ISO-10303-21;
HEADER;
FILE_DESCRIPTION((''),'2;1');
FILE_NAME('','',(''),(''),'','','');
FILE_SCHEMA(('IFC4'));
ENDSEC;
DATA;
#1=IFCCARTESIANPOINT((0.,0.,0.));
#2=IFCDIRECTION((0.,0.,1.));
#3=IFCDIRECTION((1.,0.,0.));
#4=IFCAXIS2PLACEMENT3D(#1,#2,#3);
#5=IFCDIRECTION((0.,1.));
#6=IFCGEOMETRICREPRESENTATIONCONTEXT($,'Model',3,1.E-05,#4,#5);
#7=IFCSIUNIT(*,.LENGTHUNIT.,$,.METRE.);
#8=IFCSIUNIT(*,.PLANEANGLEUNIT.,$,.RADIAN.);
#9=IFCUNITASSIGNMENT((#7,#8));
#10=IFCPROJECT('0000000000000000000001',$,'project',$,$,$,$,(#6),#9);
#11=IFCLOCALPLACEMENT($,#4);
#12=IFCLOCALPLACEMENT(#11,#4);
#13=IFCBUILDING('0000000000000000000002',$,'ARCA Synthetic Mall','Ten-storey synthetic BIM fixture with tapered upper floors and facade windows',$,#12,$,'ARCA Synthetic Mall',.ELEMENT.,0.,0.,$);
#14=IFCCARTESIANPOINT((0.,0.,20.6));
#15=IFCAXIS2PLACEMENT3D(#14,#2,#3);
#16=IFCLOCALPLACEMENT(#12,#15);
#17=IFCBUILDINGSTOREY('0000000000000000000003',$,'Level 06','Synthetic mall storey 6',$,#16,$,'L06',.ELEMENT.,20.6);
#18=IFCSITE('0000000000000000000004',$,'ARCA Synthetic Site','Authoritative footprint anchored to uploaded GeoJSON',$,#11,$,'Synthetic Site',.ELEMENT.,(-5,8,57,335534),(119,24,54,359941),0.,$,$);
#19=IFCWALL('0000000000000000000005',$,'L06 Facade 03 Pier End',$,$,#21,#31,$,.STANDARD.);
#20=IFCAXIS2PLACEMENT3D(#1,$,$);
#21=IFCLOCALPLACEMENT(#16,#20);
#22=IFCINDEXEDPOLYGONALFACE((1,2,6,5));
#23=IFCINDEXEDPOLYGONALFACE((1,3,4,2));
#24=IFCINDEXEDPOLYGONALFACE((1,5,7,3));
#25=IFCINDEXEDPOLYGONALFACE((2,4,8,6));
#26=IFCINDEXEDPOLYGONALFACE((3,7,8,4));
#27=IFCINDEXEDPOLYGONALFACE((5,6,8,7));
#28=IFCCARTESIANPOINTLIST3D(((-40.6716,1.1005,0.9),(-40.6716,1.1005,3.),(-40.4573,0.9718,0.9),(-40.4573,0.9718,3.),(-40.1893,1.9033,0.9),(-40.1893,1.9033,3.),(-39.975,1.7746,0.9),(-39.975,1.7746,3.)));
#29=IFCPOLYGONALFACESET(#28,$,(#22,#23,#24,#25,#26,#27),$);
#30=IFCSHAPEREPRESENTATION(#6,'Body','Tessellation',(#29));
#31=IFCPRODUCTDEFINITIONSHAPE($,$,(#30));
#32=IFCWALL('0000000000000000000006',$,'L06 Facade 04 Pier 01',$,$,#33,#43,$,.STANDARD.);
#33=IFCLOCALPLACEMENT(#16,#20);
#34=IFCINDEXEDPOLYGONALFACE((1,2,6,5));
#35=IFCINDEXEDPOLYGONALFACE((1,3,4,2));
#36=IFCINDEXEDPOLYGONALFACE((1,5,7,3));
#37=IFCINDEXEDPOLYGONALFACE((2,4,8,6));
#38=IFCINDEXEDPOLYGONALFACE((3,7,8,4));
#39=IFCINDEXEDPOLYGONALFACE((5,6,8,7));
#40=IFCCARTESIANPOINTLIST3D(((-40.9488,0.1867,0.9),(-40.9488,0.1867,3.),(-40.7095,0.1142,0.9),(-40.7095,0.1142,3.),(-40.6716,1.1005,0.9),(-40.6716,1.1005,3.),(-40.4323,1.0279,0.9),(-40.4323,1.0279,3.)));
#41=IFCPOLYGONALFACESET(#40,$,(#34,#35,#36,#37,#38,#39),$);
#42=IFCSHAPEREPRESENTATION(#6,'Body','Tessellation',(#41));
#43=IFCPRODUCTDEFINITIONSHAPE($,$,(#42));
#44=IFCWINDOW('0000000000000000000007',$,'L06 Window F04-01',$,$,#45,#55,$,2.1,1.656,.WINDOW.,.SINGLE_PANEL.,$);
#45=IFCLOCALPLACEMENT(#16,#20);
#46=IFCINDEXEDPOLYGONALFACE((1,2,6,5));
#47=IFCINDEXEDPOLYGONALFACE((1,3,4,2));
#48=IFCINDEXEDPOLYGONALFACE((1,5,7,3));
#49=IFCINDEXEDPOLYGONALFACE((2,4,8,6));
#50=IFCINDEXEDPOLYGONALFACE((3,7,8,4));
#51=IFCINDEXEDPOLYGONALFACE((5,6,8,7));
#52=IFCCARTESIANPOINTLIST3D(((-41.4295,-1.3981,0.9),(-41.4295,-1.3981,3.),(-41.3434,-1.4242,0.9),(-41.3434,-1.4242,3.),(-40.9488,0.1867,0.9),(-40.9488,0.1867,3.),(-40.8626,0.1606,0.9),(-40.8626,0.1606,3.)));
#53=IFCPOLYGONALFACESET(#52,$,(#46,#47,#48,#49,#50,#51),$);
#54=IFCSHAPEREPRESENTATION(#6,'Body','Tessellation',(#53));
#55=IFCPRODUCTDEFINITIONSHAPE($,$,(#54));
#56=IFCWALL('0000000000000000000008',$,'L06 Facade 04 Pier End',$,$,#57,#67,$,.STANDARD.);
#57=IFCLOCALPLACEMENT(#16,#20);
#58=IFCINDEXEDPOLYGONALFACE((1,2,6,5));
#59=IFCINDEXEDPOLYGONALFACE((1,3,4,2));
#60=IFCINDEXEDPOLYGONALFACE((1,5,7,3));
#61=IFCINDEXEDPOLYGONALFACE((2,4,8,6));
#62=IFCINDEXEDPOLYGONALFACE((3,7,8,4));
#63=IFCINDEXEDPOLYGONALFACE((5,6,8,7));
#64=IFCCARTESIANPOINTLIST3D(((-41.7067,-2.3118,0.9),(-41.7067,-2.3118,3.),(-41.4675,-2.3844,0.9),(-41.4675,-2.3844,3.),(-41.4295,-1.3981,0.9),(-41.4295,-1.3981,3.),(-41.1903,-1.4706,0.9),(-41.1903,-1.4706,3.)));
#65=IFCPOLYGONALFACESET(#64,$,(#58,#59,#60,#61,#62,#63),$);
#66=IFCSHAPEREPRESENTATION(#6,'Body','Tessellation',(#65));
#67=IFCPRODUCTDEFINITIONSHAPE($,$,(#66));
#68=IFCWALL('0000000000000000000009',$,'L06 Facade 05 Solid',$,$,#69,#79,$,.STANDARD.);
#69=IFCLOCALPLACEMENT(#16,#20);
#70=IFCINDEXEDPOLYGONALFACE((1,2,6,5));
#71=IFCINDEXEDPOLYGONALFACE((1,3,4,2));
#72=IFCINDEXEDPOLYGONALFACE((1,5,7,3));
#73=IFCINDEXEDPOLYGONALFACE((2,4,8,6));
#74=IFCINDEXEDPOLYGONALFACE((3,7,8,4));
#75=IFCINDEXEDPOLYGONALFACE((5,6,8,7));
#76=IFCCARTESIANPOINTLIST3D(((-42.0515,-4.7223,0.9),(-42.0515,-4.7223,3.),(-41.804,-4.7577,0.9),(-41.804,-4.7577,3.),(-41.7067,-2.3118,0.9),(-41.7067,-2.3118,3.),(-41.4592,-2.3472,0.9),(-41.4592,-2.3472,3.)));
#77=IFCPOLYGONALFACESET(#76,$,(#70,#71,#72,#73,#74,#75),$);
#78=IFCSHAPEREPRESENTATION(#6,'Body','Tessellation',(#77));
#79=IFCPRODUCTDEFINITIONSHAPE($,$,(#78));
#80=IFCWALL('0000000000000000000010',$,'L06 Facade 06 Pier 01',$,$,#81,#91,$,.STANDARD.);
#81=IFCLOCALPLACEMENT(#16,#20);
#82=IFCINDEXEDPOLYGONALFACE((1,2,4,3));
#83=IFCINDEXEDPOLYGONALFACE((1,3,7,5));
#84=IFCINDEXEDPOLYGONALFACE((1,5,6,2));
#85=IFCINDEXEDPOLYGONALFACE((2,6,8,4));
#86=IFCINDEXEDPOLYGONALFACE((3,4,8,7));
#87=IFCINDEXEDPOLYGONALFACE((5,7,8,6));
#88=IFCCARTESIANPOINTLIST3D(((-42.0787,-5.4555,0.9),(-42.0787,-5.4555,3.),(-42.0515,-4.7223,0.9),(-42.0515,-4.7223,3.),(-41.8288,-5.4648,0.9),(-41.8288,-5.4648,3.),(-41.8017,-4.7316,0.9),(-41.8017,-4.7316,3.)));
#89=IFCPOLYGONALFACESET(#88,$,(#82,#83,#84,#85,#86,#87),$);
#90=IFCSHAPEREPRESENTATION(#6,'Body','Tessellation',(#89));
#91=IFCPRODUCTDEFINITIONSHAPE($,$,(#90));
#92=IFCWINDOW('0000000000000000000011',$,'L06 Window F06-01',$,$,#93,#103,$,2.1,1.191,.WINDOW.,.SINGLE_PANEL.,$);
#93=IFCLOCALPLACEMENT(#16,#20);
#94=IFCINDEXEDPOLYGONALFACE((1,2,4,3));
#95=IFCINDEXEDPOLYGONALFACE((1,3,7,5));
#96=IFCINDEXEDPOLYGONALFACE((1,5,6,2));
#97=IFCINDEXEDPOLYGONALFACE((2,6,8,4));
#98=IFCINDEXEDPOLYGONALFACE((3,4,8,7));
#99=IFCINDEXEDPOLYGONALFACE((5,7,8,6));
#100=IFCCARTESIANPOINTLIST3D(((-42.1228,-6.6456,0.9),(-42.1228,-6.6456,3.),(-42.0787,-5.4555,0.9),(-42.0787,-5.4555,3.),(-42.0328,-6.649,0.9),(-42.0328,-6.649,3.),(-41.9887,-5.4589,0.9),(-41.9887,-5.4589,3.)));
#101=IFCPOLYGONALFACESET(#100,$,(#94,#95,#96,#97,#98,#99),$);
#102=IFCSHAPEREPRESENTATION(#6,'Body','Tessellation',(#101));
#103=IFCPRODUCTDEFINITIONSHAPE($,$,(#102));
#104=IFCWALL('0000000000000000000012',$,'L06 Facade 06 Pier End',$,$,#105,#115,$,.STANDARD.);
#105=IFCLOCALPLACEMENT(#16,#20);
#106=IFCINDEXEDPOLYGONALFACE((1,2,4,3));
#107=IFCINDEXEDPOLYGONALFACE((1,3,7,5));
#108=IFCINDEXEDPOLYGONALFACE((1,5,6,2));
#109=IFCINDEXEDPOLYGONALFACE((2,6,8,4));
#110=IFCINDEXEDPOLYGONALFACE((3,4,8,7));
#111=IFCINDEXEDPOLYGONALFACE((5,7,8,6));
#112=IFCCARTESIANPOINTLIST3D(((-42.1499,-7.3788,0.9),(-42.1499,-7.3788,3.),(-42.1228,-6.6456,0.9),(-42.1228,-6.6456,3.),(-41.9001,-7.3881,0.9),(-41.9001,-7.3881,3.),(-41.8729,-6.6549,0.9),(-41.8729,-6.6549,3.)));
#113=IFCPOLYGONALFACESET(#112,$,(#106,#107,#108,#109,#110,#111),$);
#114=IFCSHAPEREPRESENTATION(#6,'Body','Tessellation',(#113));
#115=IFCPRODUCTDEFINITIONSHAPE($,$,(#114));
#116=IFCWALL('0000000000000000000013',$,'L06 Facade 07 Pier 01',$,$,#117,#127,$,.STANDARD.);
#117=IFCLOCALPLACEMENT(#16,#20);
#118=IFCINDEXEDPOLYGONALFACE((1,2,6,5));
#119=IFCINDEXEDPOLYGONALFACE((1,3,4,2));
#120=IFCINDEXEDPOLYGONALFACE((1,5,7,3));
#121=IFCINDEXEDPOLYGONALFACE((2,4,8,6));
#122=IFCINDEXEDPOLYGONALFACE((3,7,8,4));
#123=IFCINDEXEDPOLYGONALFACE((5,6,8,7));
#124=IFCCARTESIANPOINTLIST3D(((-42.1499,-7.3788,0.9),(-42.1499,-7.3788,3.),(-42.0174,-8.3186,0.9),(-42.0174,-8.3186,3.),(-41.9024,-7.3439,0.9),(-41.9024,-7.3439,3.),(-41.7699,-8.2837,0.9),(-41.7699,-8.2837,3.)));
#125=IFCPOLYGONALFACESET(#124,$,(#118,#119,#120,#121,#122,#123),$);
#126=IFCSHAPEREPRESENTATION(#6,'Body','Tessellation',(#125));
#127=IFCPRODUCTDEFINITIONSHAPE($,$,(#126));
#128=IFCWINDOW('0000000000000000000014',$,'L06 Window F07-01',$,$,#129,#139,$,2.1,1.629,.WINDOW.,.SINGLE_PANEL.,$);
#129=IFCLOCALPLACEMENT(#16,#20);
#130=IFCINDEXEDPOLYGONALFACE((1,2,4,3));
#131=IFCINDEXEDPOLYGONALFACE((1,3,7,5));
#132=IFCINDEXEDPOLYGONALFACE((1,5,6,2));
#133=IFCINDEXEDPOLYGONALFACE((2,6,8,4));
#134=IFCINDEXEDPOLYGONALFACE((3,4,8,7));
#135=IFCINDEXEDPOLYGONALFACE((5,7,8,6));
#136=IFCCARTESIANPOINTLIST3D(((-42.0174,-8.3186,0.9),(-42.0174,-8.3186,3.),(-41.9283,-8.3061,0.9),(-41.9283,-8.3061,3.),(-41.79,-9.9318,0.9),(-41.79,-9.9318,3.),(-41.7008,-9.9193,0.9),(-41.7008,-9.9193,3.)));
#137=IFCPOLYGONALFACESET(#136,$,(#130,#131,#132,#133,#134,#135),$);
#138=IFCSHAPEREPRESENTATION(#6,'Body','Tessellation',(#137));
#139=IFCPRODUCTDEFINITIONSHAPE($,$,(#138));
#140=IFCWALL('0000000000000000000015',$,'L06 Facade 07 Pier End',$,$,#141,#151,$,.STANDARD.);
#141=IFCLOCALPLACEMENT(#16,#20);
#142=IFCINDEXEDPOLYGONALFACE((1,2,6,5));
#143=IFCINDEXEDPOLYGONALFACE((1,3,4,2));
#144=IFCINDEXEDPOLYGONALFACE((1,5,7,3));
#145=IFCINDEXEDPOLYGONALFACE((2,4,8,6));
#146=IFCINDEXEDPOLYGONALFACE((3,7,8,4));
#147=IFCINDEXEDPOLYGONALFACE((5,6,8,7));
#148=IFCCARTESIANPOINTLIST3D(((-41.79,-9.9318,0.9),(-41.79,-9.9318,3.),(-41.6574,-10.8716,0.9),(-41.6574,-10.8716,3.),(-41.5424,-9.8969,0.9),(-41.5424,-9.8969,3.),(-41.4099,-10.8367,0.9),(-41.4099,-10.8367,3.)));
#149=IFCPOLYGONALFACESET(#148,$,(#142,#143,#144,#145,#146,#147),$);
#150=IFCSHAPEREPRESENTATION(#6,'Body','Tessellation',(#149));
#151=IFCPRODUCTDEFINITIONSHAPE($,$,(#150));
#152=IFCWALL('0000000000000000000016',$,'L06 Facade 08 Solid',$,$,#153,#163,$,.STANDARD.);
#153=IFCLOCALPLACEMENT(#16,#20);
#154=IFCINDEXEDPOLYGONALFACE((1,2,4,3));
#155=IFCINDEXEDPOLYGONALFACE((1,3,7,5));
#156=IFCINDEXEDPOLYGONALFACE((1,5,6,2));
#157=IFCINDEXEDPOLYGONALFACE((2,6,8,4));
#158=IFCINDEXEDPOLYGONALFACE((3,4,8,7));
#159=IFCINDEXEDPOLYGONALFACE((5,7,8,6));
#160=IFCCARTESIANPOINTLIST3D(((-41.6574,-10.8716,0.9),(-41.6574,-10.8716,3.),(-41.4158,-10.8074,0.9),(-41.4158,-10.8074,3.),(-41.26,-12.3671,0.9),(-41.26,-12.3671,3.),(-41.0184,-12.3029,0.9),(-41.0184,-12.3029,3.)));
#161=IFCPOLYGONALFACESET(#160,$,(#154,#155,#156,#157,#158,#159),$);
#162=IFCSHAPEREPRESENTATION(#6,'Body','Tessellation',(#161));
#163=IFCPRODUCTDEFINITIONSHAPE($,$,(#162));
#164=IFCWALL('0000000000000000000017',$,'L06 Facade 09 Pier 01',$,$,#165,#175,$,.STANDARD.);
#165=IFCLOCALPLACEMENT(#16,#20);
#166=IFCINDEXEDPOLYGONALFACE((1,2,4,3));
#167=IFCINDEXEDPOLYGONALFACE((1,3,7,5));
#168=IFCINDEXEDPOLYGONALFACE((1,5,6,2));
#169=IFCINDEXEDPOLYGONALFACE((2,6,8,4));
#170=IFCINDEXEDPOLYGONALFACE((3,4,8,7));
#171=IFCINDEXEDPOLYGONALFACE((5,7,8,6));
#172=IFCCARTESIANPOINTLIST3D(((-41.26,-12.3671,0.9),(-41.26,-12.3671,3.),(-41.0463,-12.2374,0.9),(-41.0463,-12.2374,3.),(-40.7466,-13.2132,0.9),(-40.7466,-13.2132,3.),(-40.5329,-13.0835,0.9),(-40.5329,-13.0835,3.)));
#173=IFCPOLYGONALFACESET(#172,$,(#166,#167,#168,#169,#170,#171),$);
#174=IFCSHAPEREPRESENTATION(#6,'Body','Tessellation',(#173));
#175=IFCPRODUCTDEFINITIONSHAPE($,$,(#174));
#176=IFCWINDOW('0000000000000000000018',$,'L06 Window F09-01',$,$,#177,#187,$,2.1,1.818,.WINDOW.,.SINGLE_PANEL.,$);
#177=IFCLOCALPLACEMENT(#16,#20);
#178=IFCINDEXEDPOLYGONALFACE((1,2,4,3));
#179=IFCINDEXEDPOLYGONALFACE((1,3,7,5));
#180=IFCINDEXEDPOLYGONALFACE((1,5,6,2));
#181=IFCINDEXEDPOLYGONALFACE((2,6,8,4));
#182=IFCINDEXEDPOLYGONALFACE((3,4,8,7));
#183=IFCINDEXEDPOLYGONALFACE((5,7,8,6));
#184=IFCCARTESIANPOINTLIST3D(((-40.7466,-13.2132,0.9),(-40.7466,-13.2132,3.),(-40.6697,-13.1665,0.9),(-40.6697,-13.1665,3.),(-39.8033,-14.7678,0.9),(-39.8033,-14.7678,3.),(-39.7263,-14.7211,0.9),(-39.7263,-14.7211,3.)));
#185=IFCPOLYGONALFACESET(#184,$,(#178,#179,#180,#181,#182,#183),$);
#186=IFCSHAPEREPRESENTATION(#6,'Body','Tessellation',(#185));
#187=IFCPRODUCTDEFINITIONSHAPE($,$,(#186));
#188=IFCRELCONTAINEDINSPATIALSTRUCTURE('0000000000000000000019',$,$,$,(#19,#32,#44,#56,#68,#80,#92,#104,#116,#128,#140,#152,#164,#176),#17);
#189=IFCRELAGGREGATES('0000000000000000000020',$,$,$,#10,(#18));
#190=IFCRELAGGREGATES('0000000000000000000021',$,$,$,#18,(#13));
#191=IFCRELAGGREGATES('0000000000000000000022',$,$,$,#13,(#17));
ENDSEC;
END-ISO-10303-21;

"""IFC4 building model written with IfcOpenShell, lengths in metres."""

from ifc_helpers import new_model, si_unit, direction, frame, origin_with_axes, place, context, project, spatial, polyline, outline, extrude, element, save


model = new_model("IFC4")

# Units and contexts
model_context = context("Model", 3, precision=1e-05, world=origin_with_axes(), true_north=direction((0.0, 1.0)))
ifc_project = project(units=[si_unit("LENGTHUNIT", "METRE"), si_unit("PLANEANGLEUNIT", "RADIAN")], contexts=[model_context])

# Site, building, storey
site_placement = place(None, origin_with_axes())
site = spatial("IfcSite", under=ifc_project, at=site_placement, Name="ARCA Synthetic Site", Description="Authoritative footprint anchored to uploaded GeoJSON", LongName="Synthetic Site", CompositionType="ELEMENT", RefLatitude=(-5, 8, 57, 335534), RefLongitude=(119, 24, 54, 359941), RefElevation=0.0)
building_placement = place(site_placement, origin_with_axes())
building = spatial("IfcBuilding", under=site, at=building_placement, Name="ARCA Synthetic Mall", Description="Ten-storey synthetic BIM fixture with tapered upper floors and facade windows", LongName="ARCA Synthetic Mall", CompositionType="ELEMENT", ElevationOfRefHeight=0.0, ElevationOfTerrain=0.0)
storey_placement = place(building_placement, frame((0.0, 0.0, 20.6), z_axis=(0.0, 0.0, 1.0), x_axis=(1.0, 0.0, 0.0)))
storey = spatial("IfcBuildingStorey", under=building, at=storey_placement, Name="Level 06", Description="Synthetic mall storey 6", LongName="L06", CompositionType="ELEMENT", Elevation=20.6)

# Walls
wall_1_placement = place(storey_placement, frame((0.0, 0.0, 0.9), z_axis=(0.0, 0.0, 1.0), x_axis=(1.0, 0.0, 0.0)))
element("IfcWall", 1, at=wall_1_placement, inside=storey, Name="L06 Facade 03 Pier End", PredefinedType="STANDARD", context=model_context, shape_type="SweptSolid", body=[
    extrude(outline(polyline([(-40.1893, 1.9033), (-40.6716, 1.1005), (-40.4573, 0.9718), (-39.975, 1.7746), (-40.1893, 1.9033)])), origin_with_axes(), (0.0, 0.0, 1.0), 2.1),
])
wall_2_placement = place(storey_placement, frame((0.0, 0.0, 0.9), z_axis=(0.0, 0.0, 1.0), x_axis=(1.0, 0.0, 0.0)))
element("IfcWall", 2, at=wall_2_placement, inside=storey, Name="L06 Facade 04 Pier 01", PredefinedType="STANDARD", context=model_context, shape_type="SweptSolid", body=[
    extrude(outline(polyline([(-40.6716, 1.1005), (-40.9488, 0.1867), (-40.7095, 0.1142), (-40.4323, 1.0279), (-40.6716, 1.1005)])), origin_with_axes(), (0.0, 0.0, 1.0), 2.1),
])

# Window
window_1_placement = place(storey_placement, frame((0.0, 0.0, 0.9), z_axis=(0.0, 0.0, 1.0), x_axis=(1.0, 0.0, 0.0)))
element("IfcWindow", 3, at=window_1_placement, inside=storey, Name="L06 Window F04-01", OverallHeight=2.1, OverallWidth=1.656, PartitioningType="SINGLE_PANEL", PredefinedType="WINDOW", context=model_context, shape_type="SweptSolid", body=[
    extrude(outline(polyline([(-40.9488, 0.1867), (-41.4295, -1.3981), (-41.3434, -1.4242), (-40.8626, 0.1606), (-40.9488, 0.1867)])), origin_with_axes(), (0.0, 0.0, 1.0), 2.1),
])

# Walls
wall_3_placement = place(storey_placement, frame((0.0, 0.0, 0.9), z_axis=(0.0, 0.0, 1.0), x_axis=(1.0, 0.0, 0.0)))
element("IfcWall", 4, at=wall_3_placement, inside=storey, Name="L06 Facade 04 Pier End", PredefinedType="STANDARD", context=model_context, shape_type="SweptSolid", body=[
    extrude(outline(polyline([(-41.4295, -1.3981), (-41.7067, -2.3118), (-41.4675, -2.3844), (-41.1903, -1.4706), (-41.4295, -1.3981)])), origin_with_axes(), (0.0, 0.0, 1.0), 2.1),
])
wall_4_placement = place(storey_placement, frame((0.0, 0.0, 0.9), z_axis=(0.0, 0.0, 1.0), x_axis=(1.0, 0.0, 0.0)))
element("IfcWall", 5, at=wall_4_placement, inside=storey, Name="L06 Facade 05 Solid", PredefinedType="STANDARD", context=model_context, shape_type="SweptSolid", body=[
    extrude(outline(polyline([(-41.7067, -2.3118), (-42.0515, -4.7223), (-41.804, -4.7577), (-41.4592, -2.3472), (-41.7067, -2.3118)])), origin_with_axes(), (0.0, 0.0, 1.0), 2.1),
])
wall_5_placement = place(storey_placement, frame((0.0, 0.0, 0.9), z_axis=(0.0, 0.0, 1.0), x_axis=(1.0, 0.0, 0.0)))
element("IfcWall", 6, at=wall_5_placement, inside=storey, Name="L06 Facade 06 Pier 01", PredefinedType="STANDARD", context=model_context, shape_type="SweptSolid", body=[
    extrude(outline(polyline([(-42.0515, -4.7223), (-42.0787, -5.4555), (-41.8288, -5.4648), (-41.8017, -4.7316), (-42.0515, -4.7223)])), origin_with_axes(), (0.0, 0.0, 1.0), 2.1),
])

# Window
window_2_placement = place(storey_placement, frame((0.0, 0.0, 0.9), z_axis=(0.0, 0.0, 1.0), x_axis=(1.0, 0.0, 0.0)))
element("IfcWindow", 7, at=window_2_placement, inside=storey, Name="L06 Window F06-01", OverallHeight=2.1, OverallWidth=1.191, PartitioningType="SINGLE_PANEL", PredefinedType="WINDOW", context=model_context, shape_type="SweptSolid", body=[
    extrude(outline(polyline([(-42.0787, -5.4555), (-42.1228, -6.6456), (-42.0328, -6.649), (-41.9887, -5.4589), (-42.0787, -5.4555)])), origin_with_axes(), (0.0, 0.0, 1.0), 2.1),
])

# Walls
wall_6_placement = place(storey_placement, frame((0.0, 0.0, 0.9), z_axis=(0.0, 0.0, 1.0), x_axis=(1.0, 0.0, 0.0)))
element("IfcWall", 8, at=wall_6_placement, inside=storey, Name="L06 Facade 06 Pier End", PredefinedType="STANDARD", context=model_context, shape_type="SweptSolid", body=[
    extrude(outline(polyline([(-42.1228, -6.6456), (-42.1499, -7.3788), (-41.9001, -7.3881), (-41.8729, -6.6549), (-42.1228, -6.6456)])), origin_with_axes(), (0.0, 0.0, 1.0), 2.1),
])
wall_7_placement = place(storey_placement, frame((0.0, 0.0, 0.9), z_axis=(0.0, 0.0, 1.0), x_axis=(1.0, 0.0, 0.0)))
element("IfcWall", 9, at=wall_7_placement, inside=storey, Name="L06 Facade 07 Pier 01", PredefinedType="STANDARD", context=model_context, shape_type="SweptSolid", body=[
    extrude(outline(polyline([(-42.1499, -7.3788), (-42.0174, -8.3186), (-41.7699, -8.2837), (-41.9024, -7.3439), (-42.1499, -7.3788)])), origin_with_axes(), (0.0, 0.0, 1.0), 2.1),
])

# Window
window_3_placement = place(storey_placement, frame((0.0, 0.0, 0.9), z_axis=(0.0, 0.0, 1.0), x_axis=(1.0, 0.0, 0.0)))
element("IfcWindow", 10, at=window_3_placement, inside=storey, Name="L06 Window F07-01", OverallHeight=2.1, OverallWidth=1.629, PartitioningType="SINGLE_PANEL", PredefinedType="WINDOW", context=model_context, shape_type="SweptSolid", body=[
    extrude(outline(polyline([(-42.0174, -8.3186), (-41.79, -9.9318), (-41.7008, -9.9193), (-41.9283, -8.3061), (-42.0174, -8.3186)])), origin_with_axes(), (0.0, 0.0, 1.0), 2.1),
])

# Walls
wall_8_placement = place(storey_placement, frame((0.0, 0.0, 0.9), z_axis=(0.0, 0.0, 1.0), x_axis=(1.0, 0.0, 0.0)))
element("IfcWall", 11, at=wall_8_placement, inside=storey, Name="L06 Facade 07 Pier End", PredefinedType="STANDARD", context=model_context, shape_type="SweptSolid", body=[
    extrude(outline(polyline([(-41.79, -9.9318), (-41.6574, -10.8716), (-41.4099, -10.8367), (-41.5424, -9.8969), (-41.79, -9.9318)])), origin_with_axes(), (0.0, 0.0, 1.0), 2.1),
])
wall_9_placement = place(storey_placement, frame((0.0, 0.0, 0.9), z_axis=(0.0, 0.0, 1.0), x_axis=(1.0, 0.0, 0.0)))
element("IfcWall", 12, at=wall_9_placement, inside=storey, Name="L06 Facade 08 Solid", PredefinedType="STANDARD", context=model_context, shape_type="SweptSolid", body=[
    extrude(outline(polyline([(-41.6574, -10.8716), (-41.26, -12.3671), (-41.0184, -12.3029), (-41.4158, -10.8074), (-41.6574, -10.8716)])), origin_with_axes(), (0.0, 0.0, 1.0), 2.1),
])
wall_10_placement = place(storey_placement, frame((0.0, 0.0, 0.9), z_axis=(0.0, 0.0, 1.0), x_axis=(1.0, 0.0, 0.0)))
element("IfcWall", 13, at=wall_10_placement, inside=storey, Name="L06 Facade 09 Pier 01", PredefinedType="STANDARD", context=model_context, shape_type="SweptSolid", body=[
    extrude(outline(polyline([(-41.26, -12.3671), (-40.7466, -13.2132), (-40.5329, -13.0835), (-41.0463, -12.2374), (-41.26, -12.3671)])), origin_with_axes(), (0.0, 0.0, 1.0), 2.1),
])

# Window
window_4_placement = place(storey_placement, frame((0.0, 0.0, 0.9), z_axis=(0.0, 0.0, 1.0), x_axis=(1.0, 0.0, 0.0)))
element("IfcWindow", 14, at=window_4_placement, inside=storey, Name="L06 Window F09-01", OverallHeight=2.1, OverallWidth=1.818, PartitioningType="SINGLE_PANEL", PredefinedType="WINDOW", context=model_context, shape_type="SweptSolid", body=[
    extrude(outline(polyline([(-40.7466, -13.2132), (-39.8033, -14.7678), (-39.7263, -14.7211), (-40.6697, -13.1665), (-40.7466, -13.2132)])), origin_with_axes(), (0.0, 0.0, 1.0), 2.1),
])

save(model, "model.ifc")
